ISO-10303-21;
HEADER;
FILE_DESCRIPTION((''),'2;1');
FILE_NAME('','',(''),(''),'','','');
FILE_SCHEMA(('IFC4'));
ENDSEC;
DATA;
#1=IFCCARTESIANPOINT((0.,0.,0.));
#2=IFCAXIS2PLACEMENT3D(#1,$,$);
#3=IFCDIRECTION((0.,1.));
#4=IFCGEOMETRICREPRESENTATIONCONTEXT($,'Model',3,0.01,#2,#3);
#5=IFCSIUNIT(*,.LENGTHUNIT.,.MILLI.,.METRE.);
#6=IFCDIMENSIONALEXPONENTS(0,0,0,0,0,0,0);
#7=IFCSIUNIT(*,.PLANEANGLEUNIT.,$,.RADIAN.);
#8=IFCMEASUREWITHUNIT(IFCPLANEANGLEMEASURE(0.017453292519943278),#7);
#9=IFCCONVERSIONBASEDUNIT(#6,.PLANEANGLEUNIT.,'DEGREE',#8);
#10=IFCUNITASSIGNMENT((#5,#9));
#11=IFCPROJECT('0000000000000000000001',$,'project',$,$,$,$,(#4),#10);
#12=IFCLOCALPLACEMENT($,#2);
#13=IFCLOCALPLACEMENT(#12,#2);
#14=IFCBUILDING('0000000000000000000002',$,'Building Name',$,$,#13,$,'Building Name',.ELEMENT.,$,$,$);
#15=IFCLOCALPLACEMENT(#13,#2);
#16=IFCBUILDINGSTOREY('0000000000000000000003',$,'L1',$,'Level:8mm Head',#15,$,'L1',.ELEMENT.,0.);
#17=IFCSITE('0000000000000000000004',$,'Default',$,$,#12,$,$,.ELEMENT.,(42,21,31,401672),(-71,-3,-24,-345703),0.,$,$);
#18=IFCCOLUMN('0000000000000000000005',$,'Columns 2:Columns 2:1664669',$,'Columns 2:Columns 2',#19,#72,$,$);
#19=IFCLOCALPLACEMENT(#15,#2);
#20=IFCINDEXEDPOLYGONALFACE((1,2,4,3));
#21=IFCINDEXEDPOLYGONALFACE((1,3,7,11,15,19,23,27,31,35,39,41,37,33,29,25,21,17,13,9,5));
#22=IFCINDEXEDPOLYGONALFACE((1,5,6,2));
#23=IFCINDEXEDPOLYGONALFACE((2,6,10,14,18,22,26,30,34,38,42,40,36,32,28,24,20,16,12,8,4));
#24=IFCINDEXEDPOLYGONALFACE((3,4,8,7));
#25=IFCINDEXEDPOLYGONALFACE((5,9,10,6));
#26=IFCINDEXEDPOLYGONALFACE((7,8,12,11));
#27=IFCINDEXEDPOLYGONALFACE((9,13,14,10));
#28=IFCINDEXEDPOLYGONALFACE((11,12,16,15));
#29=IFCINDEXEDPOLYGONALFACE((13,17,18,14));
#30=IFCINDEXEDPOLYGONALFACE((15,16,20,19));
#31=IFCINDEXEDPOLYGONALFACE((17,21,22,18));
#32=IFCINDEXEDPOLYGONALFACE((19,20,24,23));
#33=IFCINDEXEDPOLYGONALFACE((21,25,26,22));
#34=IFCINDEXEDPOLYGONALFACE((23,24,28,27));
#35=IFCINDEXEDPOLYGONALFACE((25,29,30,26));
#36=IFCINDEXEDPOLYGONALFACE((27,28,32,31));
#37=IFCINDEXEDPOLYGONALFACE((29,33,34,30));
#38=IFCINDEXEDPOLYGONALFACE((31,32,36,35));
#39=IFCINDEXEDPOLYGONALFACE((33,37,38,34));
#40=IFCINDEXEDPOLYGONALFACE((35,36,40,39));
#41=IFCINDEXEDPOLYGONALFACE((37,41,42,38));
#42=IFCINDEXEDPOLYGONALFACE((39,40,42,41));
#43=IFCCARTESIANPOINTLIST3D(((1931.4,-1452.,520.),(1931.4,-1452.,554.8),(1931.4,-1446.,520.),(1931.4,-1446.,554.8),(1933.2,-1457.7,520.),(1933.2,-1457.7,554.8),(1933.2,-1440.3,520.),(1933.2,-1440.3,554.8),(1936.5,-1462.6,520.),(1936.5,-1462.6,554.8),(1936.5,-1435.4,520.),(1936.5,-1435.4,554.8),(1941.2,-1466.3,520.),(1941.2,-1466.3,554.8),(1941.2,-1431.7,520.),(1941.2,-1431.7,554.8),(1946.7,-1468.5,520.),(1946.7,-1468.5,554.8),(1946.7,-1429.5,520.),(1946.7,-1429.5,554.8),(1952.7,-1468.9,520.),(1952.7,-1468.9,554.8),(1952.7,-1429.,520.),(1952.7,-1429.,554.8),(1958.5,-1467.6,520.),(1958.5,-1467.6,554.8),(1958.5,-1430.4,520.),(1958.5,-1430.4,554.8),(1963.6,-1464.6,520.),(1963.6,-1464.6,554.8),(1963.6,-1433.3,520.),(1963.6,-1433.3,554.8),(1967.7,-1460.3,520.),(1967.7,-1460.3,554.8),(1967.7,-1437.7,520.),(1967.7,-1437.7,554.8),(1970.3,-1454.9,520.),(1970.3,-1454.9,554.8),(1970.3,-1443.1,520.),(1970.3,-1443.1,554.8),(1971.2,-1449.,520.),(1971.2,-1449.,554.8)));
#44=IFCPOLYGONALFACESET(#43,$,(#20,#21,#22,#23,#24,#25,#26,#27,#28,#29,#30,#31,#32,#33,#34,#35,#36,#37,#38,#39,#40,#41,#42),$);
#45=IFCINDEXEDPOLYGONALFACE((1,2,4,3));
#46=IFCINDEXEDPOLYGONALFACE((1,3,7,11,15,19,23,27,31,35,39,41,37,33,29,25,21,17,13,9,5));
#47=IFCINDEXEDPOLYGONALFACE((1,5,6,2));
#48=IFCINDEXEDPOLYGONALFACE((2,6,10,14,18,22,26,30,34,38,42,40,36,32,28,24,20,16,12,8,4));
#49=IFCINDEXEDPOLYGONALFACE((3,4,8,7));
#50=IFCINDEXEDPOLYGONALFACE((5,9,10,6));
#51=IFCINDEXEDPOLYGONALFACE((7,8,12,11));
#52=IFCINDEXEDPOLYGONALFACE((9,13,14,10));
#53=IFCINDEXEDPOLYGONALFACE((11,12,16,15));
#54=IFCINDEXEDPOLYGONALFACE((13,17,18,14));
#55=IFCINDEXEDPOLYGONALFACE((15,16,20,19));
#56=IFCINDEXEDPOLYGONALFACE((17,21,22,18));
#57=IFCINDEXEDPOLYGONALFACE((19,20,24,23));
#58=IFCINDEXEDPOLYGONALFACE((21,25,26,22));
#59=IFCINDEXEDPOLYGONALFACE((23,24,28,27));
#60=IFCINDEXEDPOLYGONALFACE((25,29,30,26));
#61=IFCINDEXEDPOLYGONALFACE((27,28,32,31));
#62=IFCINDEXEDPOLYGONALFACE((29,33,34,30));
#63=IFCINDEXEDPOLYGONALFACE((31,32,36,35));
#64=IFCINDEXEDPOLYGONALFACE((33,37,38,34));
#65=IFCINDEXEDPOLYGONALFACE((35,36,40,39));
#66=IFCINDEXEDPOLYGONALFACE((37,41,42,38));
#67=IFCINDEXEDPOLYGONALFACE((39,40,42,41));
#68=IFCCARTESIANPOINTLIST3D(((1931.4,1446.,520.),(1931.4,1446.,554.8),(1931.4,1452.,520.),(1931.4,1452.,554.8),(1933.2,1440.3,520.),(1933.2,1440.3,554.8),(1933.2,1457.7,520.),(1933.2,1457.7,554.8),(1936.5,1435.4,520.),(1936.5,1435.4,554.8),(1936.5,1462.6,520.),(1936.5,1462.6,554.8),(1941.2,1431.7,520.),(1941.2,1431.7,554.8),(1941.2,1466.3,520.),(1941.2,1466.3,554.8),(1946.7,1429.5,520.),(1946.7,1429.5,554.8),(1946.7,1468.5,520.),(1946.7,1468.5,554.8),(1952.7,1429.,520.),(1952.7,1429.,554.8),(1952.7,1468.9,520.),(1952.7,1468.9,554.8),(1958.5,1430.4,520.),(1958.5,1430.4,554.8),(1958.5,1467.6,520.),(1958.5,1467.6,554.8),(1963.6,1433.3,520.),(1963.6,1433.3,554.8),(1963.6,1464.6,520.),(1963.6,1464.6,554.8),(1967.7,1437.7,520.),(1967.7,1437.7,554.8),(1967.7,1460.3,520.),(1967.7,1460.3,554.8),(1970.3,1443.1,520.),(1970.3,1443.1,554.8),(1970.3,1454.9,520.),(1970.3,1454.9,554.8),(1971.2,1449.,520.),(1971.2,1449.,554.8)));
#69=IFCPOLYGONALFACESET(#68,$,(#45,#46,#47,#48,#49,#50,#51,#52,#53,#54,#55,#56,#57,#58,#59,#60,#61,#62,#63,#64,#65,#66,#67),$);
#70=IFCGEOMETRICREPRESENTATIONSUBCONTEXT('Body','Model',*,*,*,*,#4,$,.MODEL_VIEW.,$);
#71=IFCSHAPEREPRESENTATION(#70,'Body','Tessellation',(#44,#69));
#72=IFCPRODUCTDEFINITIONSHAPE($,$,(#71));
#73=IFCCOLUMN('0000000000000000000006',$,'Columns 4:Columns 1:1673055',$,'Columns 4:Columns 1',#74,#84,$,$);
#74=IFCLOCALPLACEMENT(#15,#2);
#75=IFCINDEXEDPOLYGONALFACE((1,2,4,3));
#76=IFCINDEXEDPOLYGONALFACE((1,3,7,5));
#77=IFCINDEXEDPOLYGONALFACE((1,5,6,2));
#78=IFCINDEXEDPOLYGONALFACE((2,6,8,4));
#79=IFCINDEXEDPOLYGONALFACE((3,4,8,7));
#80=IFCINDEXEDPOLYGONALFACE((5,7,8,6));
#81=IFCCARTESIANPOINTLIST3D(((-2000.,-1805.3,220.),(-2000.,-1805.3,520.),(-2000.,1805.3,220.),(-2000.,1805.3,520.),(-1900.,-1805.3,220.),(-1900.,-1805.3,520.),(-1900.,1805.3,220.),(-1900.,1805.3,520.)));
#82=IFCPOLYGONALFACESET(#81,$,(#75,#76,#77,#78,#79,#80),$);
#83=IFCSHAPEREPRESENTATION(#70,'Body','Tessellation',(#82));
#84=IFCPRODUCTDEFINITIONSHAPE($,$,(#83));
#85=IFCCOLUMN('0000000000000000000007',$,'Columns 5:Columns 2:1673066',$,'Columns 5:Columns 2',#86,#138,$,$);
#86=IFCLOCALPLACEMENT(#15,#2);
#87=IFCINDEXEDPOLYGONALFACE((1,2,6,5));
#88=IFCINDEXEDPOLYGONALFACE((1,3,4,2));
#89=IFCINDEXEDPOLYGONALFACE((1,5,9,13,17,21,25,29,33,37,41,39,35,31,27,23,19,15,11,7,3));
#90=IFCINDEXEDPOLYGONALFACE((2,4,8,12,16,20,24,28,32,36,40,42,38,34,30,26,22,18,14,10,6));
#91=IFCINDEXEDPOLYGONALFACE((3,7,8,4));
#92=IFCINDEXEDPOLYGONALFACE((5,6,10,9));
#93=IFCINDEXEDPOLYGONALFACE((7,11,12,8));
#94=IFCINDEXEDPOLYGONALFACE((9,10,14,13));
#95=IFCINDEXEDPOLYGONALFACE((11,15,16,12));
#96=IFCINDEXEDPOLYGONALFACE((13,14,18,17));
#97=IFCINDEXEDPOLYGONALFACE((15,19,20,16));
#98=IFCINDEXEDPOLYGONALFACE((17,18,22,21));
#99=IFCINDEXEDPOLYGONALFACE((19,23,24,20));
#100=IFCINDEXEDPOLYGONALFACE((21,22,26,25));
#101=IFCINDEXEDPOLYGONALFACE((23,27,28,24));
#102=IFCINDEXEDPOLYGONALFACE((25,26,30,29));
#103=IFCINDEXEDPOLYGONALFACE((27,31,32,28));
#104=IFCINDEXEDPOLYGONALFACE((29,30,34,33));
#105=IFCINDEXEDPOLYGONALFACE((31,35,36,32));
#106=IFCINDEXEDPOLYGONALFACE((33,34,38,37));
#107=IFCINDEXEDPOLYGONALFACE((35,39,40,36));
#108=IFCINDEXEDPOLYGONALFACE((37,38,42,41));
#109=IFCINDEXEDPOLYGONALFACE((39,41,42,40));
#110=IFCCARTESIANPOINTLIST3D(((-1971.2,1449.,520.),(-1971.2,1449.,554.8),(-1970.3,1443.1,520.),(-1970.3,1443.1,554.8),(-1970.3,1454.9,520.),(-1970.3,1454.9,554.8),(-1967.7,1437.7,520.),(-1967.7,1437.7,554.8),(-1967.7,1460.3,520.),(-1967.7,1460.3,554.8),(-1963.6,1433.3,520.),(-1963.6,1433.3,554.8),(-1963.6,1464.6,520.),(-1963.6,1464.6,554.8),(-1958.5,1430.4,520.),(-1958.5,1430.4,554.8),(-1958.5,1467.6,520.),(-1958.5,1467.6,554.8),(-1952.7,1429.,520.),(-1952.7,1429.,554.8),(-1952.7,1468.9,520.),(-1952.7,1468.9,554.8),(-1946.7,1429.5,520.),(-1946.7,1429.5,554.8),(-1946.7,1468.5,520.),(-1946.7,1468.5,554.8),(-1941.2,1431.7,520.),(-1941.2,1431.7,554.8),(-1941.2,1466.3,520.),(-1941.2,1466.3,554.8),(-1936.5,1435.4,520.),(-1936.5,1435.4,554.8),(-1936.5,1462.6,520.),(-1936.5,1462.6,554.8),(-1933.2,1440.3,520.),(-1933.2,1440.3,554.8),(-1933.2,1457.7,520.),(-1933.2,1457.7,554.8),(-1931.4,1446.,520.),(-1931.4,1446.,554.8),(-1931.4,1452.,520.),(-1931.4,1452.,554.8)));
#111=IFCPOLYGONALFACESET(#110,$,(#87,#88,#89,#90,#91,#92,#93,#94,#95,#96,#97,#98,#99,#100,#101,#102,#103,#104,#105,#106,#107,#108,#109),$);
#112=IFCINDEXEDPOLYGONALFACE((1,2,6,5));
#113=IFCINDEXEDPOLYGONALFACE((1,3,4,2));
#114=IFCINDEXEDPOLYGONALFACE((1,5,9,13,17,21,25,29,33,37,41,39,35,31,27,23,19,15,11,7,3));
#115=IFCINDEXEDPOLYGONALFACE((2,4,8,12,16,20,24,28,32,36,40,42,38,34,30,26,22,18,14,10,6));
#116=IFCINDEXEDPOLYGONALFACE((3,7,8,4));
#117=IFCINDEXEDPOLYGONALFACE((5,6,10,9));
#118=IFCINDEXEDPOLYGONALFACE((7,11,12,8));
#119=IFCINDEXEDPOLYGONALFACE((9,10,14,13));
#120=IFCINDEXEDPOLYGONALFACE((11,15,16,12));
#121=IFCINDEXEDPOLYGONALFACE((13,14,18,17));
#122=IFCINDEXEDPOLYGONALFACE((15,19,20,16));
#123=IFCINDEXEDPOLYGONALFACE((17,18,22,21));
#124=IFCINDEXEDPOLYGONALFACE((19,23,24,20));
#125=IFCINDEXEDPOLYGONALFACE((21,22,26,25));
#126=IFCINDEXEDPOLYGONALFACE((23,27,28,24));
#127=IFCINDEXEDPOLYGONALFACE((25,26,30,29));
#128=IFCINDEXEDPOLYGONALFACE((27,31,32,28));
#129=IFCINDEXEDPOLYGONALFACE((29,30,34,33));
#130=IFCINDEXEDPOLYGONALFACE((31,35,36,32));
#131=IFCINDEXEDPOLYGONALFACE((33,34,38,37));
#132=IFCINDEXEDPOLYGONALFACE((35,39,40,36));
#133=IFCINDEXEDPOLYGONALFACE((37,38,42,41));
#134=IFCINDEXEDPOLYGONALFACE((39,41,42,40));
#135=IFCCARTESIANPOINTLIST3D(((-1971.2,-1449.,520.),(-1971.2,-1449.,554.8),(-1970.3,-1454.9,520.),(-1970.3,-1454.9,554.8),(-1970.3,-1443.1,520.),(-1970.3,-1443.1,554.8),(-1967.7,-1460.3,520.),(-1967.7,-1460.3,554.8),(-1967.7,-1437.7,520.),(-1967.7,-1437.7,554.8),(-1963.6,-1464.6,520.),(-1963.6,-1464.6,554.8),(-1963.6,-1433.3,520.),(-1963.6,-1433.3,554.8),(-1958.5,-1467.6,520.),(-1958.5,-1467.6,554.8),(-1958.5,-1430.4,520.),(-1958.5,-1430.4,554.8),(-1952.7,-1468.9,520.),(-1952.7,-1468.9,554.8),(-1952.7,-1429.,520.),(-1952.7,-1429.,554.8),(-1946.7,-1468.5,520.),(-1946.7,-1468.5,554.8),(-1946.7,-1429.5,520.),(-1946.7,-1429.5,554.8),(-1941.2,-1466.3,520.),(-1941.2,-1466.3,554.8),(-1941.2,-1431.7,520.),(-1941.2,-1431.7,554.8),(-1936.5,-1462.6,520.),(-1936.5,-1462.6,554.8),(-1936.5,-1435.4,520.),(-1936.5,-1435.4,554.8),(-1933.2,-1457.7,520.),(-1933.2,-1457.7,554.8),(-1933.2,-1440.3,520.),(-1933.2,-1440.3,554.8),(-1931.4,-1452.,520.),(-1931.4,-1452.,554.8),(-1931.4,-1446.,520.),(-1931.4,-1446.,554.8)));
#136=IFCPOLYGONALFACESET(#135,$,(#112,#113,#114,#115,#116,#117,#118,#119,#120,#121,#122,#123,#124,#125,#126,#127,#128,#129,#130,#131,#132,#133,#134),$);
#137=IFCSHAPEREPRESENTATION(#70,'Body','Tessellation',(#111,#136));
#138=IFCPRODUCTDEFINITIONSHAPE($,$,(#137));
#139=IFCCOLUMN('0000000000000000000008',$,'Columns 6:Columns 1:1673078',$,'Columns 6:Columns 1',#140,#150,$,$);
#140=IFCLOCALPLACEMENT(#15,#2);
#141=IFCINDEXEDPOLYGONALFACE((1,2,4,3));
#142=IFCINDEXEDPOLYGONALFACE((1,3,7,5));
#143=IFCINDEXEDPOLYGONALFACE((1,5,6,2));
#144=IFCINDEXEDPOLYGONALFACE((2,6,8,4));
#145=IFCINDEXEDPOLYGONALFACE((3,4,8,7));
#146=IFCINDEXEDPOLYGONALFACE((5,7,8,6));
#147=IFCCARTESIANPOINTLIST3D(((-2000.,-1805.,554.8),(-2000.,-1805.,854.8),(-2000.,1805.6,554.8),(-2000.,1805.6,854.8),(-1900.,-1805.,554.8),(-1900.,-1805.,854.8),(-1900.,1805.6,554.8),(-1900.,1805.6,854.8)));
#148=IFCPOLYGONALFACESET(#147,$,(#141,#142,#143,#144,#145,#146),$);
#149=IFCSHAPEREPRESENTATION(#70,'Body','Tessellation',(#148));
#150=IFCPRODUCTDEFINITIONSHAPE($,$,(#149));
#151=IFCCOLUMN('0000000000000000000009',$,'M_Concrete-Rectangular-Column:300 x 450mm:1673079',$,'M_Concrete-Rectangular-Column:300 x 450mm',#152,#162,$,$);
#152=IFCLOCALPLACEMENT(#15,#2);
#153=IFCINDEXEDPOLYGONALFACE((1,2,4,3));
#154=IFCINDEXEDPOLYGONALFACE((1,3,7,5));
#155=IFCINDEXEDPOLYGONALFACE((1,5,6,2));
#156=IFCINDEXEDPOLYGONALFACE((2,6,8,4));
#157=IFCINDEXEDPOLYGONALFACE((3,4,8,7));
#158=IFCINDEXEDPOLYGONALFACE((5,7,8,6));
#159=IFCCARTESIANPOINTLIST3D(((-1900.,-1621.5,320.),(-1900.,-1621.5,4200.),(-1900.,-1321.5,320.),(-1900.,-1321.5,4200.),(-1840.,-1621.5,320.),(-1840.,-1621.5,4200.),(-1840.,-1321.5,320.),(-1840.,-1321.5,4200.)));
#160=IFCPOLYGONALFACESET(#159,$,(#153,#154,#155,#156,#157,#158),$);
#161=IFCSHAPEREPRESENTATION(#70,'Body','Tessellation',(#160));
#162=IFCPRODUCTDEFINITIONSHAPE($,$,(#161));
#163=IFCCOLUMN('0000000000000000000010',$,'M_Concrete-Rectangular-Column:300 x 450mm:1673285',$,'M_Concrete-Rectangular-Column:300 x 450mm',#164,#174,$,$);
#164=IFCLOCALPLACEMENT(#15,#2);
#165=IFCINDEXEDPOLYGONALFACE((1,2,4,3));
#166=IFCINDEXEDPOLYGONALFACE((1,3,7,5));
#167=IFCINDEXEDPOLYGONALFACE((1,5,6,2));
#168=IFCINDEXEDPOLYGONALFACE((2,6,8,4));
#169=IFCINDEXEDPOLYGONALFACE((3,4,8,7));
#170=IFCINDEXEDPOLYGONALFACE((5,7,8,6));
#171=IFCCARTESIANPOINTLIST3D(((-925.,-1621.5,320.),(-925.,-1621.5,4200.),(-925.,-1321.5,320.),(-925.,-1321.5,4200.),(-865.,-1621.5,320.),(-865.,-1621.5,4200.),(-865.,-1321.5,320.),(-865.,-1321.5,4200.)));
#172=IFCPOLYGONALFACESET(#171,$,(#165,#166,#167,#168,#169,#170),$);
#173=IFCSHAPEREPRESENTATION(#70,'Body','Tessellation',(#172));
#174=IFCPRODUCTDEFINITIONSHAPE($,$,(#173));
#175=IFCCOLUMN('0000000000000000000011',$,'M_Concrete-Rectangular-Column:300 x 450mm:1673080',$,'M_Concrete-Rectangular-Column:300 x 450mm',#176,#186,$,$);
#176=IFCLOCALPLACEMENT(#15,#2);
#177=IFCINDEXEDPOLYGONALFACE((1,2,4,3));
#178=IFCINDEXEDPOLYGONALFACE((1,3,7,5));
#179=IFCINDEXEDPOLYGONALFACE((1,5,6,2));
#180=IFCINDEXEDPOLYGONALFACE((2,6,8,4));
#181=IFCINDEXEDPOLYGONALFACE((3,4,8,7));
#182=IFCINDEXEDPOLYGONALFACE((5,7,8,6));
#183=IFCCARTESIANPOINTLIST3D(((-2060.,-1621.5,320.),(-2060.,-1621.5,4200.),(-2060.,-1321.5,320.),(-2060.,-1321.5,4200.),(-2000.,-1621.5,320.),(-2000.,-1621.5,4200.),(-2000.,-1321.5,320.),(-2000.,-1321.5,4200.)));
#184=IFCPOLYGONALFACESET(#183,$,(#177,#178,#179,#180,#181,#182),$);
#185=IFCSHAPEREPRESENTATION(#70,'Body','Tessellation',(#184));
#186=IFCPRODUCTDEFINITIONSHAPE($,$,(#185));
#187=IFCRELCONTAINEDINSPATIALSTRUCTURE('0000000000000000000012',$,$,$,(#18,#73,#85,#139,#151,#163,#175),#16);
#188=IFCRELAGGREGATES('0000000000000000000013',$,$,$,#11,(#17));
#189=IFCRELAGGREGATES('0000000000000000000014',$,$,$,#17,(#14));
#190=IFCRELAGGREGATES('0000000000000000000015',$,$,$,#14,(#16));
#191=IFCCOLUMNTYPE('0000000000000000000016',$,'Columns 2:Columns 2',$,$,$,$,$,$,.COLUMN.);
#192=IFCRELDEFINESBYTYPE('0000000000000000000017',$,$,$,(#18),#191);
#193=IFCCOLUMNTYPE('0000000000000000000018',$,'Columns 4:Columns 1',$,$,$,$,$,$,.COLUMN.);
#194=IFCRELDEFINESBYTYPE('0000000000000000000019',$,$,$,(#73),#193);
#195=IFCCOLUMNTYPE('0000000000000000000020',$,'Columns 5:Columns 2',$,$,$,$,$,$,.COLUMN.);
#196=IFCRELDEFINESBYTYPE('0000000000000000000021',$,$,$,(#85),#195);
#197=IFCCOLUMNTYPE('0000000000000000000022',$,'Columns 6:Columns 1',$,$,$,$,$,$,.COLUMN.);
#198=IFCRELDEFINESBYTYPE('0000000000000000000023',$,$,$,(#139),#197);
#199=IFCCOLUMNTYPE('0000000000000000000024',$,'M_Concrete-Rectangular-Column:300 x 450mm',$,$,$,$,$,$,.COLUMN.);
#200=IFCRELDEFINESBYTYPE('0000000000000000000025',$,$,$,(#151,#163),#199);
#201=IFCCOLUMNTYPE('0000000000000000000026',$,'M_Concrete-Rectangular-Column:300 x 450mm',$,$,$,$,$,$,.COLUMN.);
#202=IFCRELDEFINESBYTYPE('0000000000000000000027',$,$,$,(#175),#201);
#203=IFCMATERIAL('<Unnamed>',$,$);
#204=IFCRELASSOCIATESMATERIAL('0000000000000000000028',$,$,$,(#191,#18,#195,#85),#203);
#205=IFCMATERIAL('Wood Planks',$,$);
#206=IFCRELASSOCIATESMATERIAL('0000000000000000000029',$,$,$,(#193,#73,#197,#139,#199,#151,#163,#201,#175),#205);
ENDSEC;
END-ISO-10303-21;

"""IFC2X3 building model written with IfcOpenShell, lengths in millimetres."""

from ifc_helpers import new_model, entity, si_unit, converted_unit, direction, frame, frame_2d, origin, origin_2d_with_axis, place, context, subcontext, project, spatial, rectangle, circle, extrude, source, transform, mapped, material, type_object, type_shapes, element, save


model = new_model("IFC2X3")

# Units and contexts
model_context = context("Model", 3, precision=0.01, world=origin(), true_north=direction((0.0, 1.0)))
body_context = subcontext(model_context, "Body", "Model", "MODEL_VIEW")
ifc_project = project(units=[si_unit("LENGTHUNIT", "METRE", prefix="MILLI"), converted_unit("PLANEANGLEUNIT", "DEGREE", entity("IfcPlaneAngleMeasure", 0.017453292519943278), si_unit("PLANEANGLEUNIT", "RADIAN"), dimensions=[0, 0, 0, 0, 0, 0, 0])], contexts=[model_context])

# Site, building, storey
site_placement = place(None, origin())
site = spatial("IfcSite", under=ifc_project, at=site_placement, Name="Default", CompositionType="ELEMENT", RefLatitude=(42, 21, 31, 401672), RefLongitude=(-71, -3, -24, -345703), RefElevation=0.0)
building_placement = place(site_placement, origin())
building = spatial("IfcBuilding", under=site, at=building_placement, Name="Building Name", LongName="Building Name", CompositionType="ELEMENT")
storey_placement = place(building_placement, origin())
storey = spatial("IfcBuildingStorey", under=building, at=storey_placement, Name="L1", ObjectType="Level:8mm Head", LongName="L1", CompositionType="ELEMENT", Elevation=0.0)

# Columns
ifc_material_1 = material(Name="<Unnamed>")
column_type_1 = type_object("IfcColumnType", Name="Columns 2:Columns 2", PredefinedType="COLUMN", material=ifc_material_1)
shared_shape_1 = source(origin(), body_context, "Body", "SweptSolid", [
    extrude(circle(Radius=20.0, at=frame_2d((0.0, 0.0), x_axis=(1.0, 0.0))), frame((1951.2, -1449.0, 520.0)), (0.0, 0.0, 1.0), 34.8),
    extrude(circle(Radius=20.0, at=origin_2d_with_axis()), frame((1951.2, 1449.0, 520.0)), (0.0, 0.0, 1.0), 34.8),
])
type_shapes(column_type_1, [shared_shape_1])
column_1_placement = place(storey_placement, origin())
element("IfcColumn", 1, at=column_1_placement, inside=storey, type_object=column_type_1, material=ifc_material_1, Name="Columns 2:Columns 2:1664669", ObjectType="Columns 2:Columns 2", context=body_context, shape_type="MappedRepresentation", body=[
    mapped(shared_shape_1, transform((0.0, 0.0, 0.0), scale=1.0)),
])
ifc_material_2 = material(Name="Wood Planks")
column_type_2 = type_object("IfcColumnType", Name="Columns 4:Columns 1", PredefinedType="COLUMN", material=ifc_material_2)
shared_shape_2 = source(origin(), body_context, "Body", "SweptSolid", [
    extrude(rectangle(XDim=3610.6, YDim=100.0, at=frame_2d((0.0, 0.0), x_axis=(1.0, 0.0))), frame((-1950.0, 0.0, 220.0), z_axis=(0.0, 0.0, 1.0), x_axis=(0.0, -1.0, 0.0)), (0.0, 0.0, 1.0), 300.0),
])
type_shapes(column_type_2, [shared_shape_2])
column_2_placement = place(storey_placement, origin())
element("IfcColumn", 2, at=column_2_placement, inside=storey, type_object=column_type_2, material=ifc_material_2, Name="Columns 4:Columns 1:1673055", ObjectType="Columns 4:Columns 1", context=body_context, shape_type="MappedRepresentation", body=[
    mapped(shared_shape_2, transform((0.0, 0.0, 0.0), scale=1.0)),
])
column_type_3 = type_object("IfcColumnType", Name="Columns 5:Columns 2", PredefinedType="COLUMN", material=ifc_material_1)
shared_shape_3 = source(origin(), body_context, "Body", "SweptSolid", [
    extrude(circle(Radius=20.0, at=origin_2d_with_axis()), frame((-1951.2, 1449.0, 520.0), z_axis=(0.0, 0.0, 1.0), x_axis=(-1.0, 0.0, 0.0)), (0.0, 0.0, 1.0), 34.8),
    extrude(circle(Radius=20.0, at=frame_2d((0.0, 0.0), x_axis=(1.0, 0.0))), frame((-1951.2, -1449.0, 520.0), z_axis=(0.0, 0.0, 1.0), x_axis=(-1.0, 0.0, 0.0)), (0.0, 0.0, 1.0), 34.8),
])
type_shapes(column_type_3, [shared_shape_3])
column_3_placement = place(storey_placement, origin())
element("IfcColumn", 3, at=column_3_placement, inside=storey, type_object=column_type_3, material=ifc_material_1, Name="Columns 5:Columns 2:1673066", ObjectType="Columns 5:Columns 2", context=body_context, shape_type="MappedRepresentation", body=[
    mapped(shared_shape_3, transform((0.0, 0.0, 0.0), scale=1.0)),
])
column_type_4 = type_object("IfcColumnType", Name="Columns 6:Columns 1", PredefinedType="COLUMN", material=ifc_material_2)
shared_shape_4 = source(origin(), body_context, "Body", "SweptSolid", [
    extrude(rectangle(XDim=3610.6, YDim=100.0, at=frame_2d((0.0, 0.0), x_axis=(1.0, 0.0))), frame((-1950.0, 0.3, 554.8), z_axis=(0.0, 0.0, 1.0), x_axis=(0.0, -1.0, 0.0)), (0.0, 0.0, 1.0), 300.0),
])
type_shapes(column_type_4, [shared_shape_4])
column_4_placement = place(storey_placement, origin())
element("IfcColumn", 4, at=column_4_placement, inside=storey, type_object=column_type_4, material=ifc_material_2, Name="Columns 6:Columns 1:1673078", ObjectType="Columns 6:Columns 1", context=body_context, shape_type="MappedRepresentation", body=[
    mapped(shared_shape_4, transform((0.0, 0.0, 0.0), scale=1.0)),
])
column_type_5 = type_object("IfcColumnType", Name="M_Concrete-Rectangular-Column:300 x 450mm", PredefinedType="COLUMN", material=ifc_material_2)
shared_shape_5 = source(origin(), body_context, "Body", "SweptSolid", [
    extrude(rectangle(XDim=300.0, YDim=60.0, at=origin_2d_with_axis()), frame((0.0, 0.0, 320.0), z_axis=(0.0, 0.0, 1.0), x_axis=(0.0, 1.0, 0.0)), (0.0, 0.0, 1.0), 3880.0),
])
type_shapes(column_type_5, [shared_shape_5])
for number, where, z_axis, x_axis, name in (
    (5, (-1870.0, -1471.5, 0.0), (0.0, 0.0, 1.0), (-1.0, 0.0, 0.0), "M_Concrete-Rectangular-Column:300 x 450mm:1673079"),
    (6, (-895.0, -1471.5, 0.0), (0.0, 0.0, 1.0), (-1.0, 0.0, 0.0), "M_Concrete-Rectangular-Column:300 x 450mm:1673285"),
):
    element("IfcColumn", number, at=place(storey_placement, frame(where, z_axis=z_axis, x_axis=x_axis)), inside=storey, type_object=column_type_5, material=ifc_material_2, Name=name, ObjectType="M_Concrete-Rectangular-Column:300 x 450mm", context=body_context, shape_type="MappedRepresentation", body=[
        mapped(shared_shape_5, transform((0.0, 0.0, 0.0), scale=1.0)),
    ])
column_type_6 = type_object("IfcColumnType", Name="M_Concrete-Rectangular-Column:300 x 450mm", PredefinedType="COLUMN", material=ifc_material_2)
shared_shape_6 = source(origin(), body_context, "Body", "SweptSolid", [
    extrude(rectangle(XDim=60.0, YDim=300.0, at=origin_2d_with_axis()), frame((0.0, 0.0, 320.0), z_axis=(0.0, 0.0, 1.0), x_axis=(-1.0, 0.0, 0.0)), (0.0, 0.0, 1.0), 3880.0),
])
type_shapes(column_type_6, [shared_shape_6])
for number, where, name in (
    (7, (-2030.0, -1471.5, 0.0), "M_Concrete-Rectangular-Column:300 x 450mm:1673080"),
):
    element("IfcColumn", number, at=place(storey_placement, frame(where)), inside=storey, type_object=column_type_6, material=ifc_material_2, Name=name, ObjectType="M_Concrete-Rectangular-Column:300 x 450mm", context=body_context, shape_type="MappedRepresentation", body=[
        mapped(shared_shape_6, transform((0.0, 0.0, 0.0), scale=1.0)),
    ])

save(model, "model.ifc")
